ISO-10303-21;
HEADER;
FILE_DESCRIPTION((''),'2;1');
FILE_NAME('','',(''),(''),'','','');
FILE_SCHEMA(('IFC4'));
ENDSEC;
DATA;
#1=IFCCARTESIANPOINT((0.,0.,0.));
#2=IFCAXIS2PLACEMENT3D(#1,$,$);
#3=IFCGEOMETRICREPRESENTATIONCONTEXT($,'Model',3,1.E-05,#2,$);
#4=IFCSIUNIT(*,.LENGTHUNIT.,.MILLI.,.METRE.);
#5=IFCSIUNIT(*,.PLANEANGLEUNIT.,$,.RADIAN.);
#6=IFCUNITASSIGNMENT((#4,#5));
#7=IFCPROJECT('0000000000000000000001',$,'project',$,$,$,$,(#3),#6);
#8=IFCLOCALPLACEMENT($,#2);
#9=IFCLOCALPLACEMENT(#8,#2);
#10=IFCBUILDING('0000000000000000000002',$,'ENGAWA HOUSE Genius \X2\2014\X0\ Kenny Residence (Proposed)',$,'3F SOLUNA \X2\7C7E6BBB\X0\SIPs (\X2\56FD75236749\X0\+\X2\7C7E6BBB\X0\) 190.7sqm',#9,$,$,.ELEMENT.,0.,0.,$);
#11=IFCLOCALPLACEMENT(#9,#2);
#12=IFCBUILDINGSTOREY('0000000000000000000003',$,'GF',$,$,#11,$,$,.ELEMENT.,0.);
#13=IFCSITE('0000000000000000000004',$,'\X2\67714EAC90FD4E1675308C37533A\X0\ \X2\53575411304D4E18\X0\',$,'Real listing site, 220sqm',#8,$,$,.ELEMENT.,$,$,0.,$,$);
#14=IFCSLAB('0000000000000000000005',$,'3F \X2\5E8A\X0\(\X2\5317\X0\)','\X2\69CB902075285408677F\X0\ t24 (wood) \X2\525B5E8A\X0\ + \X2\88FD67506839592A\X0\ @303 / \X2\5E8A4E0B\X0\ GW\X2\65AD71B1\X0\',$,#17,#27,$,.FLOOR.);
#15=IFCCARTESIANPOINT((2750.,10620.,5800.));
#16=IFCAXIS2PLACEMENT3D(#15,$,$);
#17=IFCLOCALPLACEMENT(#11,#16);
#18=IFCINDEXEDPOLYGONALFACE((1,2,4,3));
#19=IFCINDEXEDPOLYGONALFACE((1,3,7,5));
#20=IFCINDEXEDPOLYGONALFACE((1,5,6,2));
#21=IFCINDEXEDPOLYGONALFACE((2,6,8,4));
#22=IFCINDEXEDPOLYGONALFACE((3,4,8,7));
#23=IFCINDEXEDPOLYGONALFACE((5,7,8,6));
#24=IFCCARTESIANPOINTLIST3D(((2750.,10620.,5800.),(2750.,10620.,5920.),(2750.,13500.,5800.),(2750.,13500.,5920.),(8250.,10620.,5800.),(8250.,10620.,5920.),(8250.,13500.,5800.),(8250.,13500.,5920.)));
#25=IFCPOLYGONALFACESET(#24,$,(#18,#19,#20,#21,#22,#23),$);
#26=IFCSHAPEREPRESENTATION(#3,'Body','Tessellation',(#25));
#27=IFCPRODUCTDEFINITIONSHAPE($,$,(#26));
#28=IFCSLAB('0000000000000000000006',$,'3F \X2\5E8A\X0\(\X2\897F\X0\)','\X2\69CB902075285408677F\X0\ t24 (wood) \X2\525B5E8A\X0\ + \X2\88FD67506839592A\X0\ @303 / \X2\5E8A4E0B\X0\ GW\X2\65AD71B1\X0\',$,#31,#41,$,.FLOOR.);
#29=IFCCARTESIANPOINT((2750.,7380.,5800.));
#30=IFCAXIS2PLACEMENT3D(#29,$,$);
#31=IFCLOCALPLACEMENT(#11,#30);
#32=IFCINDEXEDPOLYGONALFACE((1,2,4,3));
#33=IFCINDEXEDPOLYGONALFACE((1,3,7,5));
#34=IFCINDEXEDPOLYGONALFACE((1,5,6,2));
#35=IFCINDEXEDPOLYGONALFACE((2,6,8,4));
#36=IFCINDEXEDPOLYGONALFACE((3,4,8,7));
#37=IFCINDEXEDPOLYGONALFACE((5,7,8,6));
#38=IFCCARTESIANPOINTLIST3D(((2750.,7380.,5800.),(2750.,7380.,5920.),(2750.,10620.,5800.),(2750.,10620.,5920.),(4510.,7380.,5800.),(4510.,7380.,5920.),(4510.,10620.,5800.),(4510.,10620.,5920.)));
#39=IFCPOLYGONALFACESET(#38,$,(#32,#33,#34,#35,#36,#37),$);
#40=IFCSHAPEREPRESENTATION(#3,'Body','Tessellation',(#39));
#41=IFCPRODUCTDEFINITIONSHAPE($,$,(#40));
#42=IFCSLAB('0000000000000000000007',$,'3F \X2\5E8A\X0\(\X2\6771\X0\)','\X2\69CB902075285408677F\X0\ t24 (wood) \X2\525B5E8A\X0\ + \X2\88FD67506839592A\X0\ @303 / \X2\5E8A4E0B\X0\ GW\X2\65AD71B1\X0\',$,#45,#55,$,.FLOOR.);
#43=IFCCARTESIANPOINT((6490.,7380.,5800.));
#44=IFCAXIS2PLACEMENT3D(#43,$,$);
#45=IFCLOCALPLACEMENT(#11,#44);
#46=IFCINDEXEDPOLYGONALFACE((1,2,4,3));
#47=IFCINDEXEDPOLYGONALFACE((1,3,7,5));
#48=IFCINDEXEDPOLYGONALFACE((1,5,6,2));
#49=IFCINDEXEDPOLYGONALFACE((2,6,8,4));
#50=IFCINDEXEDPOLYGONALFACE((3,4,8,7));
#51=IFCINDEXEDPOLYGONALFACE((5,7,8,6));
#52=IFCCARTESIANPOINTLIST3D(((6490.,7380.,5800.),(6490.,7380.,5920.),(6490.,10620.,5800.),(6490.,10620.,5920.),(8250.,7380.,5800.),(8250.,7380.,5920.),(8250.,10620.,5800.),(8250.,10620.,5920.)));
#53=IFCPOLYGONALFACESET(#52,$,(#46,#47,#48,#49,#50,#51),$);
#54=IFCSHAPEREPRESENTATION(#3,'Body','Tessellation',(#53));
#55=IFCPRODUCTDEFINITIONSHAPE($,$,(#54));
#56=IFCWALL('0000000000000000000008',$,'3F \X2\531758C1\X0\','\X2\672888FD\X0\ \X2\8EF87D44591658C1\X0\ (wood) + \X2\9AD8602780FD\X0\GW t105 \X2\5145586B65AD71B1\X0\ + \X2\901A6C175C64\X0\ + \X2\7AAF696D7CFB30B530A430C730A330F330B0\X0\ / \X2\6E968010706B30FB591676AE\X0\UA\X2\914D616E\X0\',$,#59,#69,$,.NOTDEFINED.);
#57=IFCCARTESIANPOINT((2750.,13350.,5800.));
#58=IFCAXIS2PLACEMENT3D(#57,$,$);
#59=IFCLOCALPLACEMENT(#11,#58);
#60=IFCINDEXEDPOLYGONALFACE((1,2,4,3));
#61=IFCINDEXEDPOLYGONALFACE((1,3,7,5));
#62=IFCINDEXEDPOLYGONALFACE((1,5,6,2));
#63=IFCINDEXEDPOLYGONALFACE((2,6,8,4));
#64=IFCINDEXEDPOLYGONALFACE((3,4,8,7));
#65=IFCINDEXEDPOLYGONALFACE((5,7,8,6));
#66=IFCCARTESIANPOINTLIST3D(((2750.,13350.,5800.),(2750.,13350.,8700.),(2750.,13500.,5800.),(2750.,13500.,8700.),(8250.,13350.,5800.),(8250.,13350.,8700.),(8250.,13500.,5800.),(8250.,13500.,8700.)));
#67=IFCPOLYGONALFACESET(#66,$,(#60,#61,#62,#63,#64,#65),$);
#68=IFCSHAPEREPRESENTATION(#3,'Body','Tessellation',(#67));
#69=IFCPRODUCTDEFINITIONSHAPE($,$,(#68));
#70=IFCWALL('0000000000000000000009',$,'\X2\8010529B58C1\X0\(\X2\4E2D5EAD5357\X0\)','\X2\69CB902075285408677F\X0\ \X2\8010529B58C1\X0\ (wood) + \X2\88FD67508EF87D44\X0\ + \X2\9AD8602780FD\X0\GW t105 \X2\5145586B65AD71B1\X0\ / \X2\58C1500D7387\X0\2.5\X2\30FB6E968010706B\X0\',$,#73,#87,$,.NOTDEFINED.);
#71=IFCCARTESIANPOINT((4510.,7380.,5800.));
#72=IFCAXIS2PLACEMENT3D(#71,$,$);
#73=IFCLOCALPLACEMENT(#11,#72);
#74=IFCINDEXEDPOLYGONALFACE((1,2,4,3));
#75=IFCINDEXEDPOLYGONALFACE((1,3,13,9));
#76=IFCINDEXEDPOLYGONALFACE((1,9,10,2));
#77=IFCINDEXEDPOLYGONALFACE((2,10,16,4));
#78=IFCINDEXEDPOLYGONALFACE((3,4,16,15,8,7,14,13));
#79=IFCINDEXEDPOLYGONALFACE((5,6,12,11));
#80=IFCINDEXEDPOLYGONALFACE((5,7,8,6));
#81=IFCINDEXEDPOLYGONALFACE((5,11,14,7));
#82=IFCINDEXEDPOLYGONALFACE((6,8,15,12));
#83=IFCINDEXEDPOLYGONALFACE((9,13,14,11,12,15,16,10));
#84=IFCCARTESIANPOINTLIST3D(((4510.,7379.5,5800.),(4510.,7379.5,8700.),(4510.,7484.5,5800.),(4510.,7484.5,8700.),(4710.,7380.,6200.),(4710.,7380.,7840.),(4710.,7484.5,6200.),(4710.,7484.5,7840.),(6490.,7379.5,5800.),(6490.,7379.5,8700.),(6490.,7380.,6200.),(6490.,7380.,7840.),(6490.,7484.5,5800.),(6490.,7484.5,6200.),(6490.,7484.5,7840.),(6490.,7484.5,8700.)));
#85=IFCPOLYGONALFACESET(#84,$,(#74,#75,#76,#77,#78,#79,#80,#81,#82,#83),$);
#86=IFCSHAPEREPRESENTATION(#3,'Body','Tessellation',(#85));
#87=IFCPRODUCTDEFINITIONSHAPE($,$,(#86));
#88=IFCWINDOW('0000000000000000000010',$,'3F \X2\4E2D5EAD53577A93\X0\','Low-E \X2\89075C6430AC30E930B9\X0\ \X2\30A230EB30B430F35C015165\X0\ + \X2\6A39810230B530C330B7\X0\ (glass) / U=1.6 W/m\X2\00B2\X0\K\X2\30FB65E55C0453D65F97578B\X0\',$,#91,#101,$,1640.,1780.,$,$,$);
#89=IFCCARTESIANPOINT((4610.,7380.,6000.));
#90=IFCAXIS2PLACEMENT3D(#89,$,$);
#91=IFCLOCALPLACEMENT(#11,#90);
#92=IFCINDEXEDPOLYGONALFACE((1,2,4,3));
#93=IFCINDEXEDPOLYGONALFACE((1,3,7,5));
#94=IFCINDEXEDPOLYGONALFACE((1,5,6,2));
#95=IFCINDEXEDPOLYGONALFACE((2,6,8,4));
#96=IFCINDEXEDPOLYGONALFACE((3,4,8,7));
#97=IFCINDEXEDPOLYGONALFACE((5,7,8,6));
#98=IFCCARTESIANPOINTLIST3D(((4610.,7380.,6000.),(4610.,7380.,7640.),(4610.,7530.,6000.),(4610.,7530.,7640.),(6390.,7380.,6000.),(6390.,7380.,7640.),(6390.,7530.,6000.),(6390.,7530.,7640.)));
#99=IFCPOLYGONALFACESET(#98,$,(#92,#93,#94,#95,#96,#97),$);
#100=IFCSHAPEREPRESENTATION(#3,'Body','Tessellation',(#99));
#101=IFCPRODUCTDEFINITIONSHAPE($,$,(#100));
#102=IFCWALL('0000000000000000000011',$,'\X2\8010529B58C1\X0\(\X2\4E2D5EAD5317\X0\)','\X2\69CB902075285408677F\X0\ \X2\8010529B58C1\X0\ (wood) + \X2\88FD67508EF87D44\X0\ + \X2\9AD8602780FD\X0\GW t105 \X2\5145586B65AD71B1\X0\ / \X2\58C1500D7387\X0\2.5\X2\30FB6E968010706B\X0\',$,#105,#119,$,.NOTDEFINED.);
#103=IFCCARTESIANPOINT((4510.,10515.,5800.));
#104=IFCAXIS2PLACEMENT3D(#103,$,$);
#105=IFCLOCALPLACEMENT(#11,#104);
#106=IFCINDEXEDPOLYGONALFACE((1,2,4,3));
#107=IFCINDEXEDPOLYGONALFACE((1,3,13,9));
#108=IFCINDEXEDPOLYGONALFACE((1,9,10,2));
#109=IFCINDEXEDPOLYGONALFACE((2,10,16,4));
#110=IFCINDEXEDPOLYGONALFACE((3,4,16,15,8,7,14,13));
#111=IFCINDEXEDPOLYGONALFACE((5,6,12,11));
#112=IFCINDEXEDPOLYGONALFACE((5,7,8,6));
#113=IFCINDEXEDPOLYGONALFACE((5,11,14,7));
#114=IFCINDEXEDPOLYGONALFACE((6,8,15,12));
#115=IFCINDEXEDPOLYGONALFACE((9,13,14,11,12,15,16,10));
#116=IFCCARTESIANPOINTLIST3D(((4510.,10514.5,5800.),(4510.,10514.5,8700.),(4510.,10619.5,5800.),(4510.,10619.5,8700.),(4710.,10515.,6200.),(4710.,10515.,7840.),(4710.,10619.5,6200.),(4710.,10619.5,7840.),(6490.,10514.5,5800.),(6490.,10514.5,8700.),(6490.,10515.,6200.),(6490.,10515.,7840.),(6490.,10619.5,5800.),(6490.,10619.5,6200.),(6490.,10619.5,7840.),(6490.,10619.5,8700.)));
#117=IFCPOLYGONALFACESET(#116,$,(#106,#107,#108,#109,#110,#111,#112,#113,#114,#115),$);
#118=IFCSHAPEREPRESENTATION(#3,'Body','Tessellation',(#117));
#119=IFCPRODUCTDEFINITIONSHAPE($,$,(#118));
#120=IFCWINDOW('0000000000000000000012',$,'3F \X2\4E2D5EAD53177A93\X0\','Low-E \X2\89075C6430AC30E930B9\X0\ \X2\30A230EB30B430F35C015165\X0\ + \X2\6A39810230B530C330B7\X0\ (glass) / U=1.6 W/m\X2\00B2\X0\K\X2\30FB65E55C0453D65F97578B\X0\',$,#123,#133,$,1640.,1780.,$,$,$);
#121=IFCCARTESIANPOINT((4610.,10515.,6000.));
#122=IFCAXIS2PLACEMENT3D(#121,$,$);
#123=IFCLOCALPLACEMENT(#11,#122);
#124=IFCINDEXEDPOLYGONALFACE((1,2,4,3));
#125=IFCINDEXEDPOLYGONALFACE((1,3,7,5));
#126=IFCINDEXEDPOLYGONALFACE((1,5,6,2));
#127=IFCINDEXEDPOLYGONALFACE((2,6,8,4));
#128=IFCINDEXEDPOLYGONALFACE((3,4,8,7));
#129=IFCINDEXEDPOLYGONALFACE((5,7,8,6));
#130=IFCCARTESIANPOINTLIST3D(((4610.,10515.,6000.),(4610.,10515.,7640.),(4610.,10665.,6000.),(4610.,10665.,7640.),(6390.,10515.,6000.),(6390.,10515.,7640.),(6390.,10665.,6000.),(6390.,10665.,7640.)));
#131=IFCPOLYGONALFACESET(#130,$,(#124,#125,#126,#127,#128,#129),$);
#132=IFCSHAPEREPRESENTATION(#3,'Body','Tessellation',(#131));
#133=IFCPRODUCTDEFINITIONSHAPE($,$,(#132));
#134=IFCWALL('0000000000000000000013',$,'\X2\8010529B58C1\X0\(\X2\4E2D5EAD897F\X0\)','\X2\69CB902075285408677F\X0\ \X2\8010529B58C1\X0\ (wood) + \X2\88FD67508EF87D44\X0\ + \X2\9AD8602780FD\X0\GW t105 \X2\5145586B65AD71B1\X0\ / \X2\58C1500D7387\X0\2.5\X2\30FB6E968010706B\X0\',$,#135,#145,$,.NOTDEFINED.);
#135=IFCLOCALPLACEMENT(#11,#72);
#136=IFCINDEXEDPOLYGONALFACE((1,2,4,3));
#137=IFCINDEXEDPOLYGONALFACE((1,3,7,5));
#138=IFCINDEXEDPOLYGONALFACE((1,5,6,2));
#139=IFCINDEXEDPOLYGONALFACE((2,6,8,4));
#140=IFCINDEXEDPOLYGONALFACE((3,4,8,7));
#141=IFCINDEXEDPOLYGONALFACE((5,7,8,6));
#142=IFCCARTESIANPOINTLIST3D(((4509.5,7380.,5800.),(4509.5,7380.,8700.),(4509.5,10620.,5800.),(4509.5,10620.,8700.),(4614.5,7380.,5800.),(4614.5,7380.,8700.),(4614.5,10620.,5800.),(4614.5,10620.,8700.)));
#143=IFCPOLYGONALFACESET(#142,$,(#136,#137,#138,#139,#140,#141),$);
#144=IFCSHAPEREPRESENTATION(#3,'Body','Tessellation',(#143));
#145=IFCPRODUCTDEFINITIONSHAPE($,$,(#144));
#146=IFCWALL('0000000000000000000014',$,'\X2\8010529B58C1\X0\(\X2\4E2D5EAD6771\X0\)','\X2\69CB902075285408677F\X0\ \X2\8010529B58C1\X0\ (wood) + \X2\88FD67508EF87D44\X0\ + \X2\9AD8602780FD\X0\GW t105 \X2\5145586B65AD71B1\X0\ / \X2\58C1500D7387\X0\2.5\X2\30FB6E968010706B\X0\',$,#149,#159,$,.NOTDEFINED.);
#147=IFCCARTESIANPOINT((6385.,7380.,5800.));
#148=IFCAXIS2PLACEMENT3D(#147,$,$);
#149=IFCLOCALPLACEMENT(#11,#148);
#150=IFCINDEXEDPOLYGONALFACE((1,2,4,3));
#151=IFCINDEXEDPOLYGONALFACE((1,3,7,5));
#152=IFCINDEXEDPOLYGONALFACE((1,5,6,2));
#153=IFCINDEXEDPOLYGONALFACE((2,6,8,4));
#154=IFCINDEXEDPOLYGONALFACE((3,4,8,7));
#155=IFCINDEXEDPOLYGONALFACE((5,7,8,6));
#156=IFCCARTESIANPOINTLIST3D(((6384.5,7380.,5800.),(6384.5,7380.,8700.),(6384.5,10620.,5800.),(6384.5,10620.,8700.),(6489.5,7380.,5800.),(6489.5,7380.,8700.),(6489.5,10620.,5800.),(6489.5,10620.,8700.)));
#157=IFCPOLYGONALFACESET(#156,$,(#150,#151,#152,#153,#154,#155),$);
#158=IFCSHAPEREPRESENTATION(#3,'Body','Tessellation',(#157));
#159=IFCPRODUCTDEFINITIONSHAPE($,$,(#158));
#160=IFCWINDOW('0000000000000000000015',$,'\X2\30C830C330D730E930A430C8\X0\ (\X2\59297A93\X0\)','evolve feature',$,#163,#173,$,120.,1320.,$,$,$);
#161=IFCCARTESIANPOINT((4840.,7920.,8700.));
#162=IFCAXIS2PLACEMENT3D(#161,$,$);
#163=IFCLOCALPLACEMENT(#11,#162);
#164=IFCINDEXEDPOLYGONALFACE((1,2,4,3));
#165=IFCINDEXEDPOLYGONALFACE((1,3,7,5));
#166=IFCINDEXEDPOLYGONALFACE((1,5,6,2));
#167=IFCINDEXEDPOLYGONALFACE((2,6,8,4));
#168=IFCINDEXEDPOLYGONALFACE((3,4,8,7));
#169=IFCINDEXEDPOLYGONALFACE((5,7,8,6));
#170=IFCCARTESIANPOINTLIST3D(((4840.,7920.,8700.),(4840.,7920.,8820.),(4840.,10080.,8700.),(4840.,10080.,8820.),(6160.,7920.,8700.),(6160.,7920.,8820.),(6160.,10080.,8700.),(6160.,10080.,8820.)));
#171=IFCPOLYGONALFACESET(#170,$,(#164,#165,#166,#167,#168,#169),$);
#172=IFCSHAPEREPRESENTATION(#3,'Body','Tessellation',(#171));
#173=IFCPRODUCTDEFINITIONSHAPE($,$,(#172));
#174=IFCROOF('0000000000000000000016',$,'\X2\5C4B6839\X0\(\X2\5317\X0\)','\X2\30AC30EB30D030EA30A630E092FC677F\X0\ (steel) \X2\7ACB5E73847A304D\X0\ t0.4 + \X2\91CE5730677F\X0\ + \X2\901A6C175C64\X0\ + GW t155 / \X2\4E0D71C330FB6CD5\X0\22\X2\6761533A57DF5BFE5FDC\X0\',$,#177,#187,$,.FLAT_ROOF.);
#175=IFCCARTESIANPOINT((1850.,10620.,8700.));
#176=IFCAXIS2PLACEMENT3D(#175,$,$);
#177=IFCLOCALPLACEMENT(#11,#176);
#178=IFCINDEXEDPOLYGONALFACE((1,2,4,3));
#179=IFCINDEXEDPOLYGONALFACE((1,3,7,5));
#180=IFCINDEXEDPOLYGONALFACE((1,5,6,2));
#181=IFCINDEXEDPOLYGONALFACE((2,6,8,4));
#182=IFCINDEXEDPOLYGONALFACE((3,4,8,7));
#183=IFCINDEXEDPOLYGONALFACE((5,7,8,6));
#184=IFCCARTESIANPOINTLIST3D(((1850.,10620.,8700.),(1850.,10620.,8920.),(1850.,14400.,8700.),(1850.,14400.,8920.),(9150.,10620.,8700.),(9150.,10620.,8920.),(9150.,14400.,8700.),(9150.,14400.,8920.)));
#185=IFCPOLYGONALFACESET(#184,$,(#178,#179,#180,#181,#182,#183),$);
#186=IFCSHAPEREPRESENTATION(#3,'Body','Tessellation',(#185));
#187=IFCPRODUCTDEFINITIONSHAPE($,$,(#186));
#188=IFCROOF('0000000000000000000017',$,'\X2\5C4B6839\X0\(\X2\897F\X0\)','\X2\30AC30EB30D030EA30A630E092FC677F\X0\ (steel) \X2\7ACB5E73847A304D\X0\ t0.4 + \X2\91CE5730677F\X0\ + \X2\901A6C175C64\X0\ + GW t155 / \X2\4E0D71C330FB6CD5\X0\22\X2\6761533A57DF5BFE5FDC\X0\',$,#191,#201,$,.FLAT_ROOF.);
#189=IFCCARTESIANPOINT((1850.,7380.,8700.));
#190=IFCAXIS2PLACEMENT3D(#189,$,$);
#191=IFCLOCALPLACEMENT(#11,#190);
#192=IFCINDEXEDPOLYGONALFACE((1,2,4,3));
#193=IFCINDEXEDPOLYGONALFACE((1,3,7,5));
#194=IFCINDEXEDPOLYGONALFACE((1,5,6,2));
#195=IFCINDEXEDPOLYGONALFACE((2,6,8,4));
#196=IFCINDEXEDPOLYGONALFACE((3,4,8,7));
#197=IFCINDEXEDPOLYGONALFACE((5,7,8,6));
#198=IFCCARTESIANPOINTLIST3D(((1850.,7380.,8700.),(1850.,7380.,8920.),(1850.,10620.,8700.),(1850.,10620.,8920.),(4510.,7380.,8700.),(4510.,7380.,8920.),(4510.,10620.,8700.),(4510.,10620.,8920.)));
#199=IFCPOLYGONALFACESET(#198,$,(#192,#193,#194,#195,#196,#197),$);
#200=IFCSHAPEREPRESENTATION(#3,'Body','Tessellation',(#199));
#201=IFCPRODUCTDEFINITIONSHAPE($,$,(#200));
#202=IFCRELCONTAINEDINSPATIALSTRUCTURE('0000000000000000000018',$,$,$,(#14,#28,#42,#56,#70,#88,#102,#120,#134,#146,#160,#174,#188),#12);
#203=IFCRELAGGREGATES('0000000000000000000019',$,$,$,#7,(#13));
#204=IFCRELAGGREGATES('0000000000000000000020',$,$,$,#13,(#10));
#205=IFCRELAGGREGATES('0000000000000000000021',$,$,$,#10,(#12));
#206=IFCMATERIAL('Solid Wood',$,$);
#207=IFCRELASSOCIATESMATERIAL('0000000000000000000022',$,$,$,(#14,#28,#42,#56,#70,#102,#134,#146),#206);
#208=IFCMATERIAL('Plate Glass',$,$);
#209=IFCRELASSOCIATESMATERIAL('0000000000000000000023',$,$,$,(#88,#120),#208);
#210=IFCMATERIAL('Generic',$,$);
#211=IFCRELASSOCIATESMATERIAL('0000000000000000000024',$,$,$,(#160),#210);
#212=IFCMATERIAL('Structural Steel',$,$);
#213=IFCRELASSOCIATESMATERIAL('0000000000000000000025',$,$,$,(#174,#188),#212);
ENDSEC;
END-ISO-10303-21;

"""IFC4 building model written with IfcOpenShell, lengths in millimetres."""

from ifc_helpers import new_model, si_unit, frame, frame_2d, origin, place, context, project, spatial, rectangle, extrude, material, element, fill, save


model = new_model("IFC4")

# Units and contexts
model_context = context("Model", 3, precision=1e-05, world=origin())
ifc_project = project(units=[si_unit("LENGTHUNIT", "METRE", prefix="MILLI"), si_unit("PLANEANGLEUNIT", "RADIAN")], contexts=[model_context])

# Site, building, storey
site_placement = place(None, origin())
site = spatial("IfcSite", under=ifc_project, at=site_placement, Name="東京都世田谷区 南向き丘", ObjectType="Real listing site, 220sqm", CompositionType="ELEMENT", RefElevation=0.0)
building_placement = place(site_placement, origin())
building = spatial("IfcBuilding", under=site, at=building_placement, Name="ENGAWA HOUSE Genius — Kenny Residence (Proposed)", ObjectType="3F SOLUNA 籾殻SIPs (国産杉+籾殻) 190.7sqm", CompositionType="ELEMENT", ElevationOfRefHeight=0.0, ElevationOfTerrain=0.0)
storey_placement = place(building_placement, origin())
storey = spatial("IfcBuildingStorey", under=building, at=storey_placement, Name="GF", CompositionType="ELEMENT", Elevation=0.0)

# Slabs
ifc_material_1 = material(Name="Solid Wood")
slab_1_placement = place(storey_placement, frame((2750.0, 10620.0, 5800.0)))
element("IfcSlab", 1, at=slab_1_placement, inside=storey, material=ifc_material_1, Name="3F 床(北)", Description="構造用合板 t24 (wood) 剛床 + 製材根太 @303 / 床下 GW断熱", PredefinedType="FLOOR", context=model_context, shape_type="SweptSolid", body=[
    extrude(rectangle(XDim=5500.0, YDim=2880.0, at=frame_2d((2750.0, 1440.0))), frame((2750.0, 10620.0, 5800.0)), (0.0, 0.0, 1.0), 120.0),
])
slab_2_placement = place(storey_placement, frame((2750.0, 7380.0, 5800.0)))
element("IfcSlab", 2, at=slab_2_placement, inside=storey, material=ifc_material_1, Name="3F 床(西)", Description="構造用合板 t24 (wood) 剛床 + 製材根太 @303 / 床下 GW断熱", PredefinedType="FLOOR", context=model_context, shape_type="SweptSolid", body=[
    extrude(rectangle(XDim=1760.0, YDim=3240.0, at=frame_2d((880.0, 1620.0))), frame((2750.0, 7380.0, 5800.0)), (0.0, 0.0, 1.0), 120.0),
])
slab_3_placement = place(storey_placement, frame((6490.0, 7380.0, 5800.0)))
element("IfcSlab", 3, at=slab_3_placement, inside=storey, material=ifc_material_1, Name="3F 床(東)", Description="構造用合板 t24 (wood) 剛床 + 製材根太 @303 / 床下 GW断熱", PredefinedType="FLOOR", context=model_context, shape_type="SweptSolid", body=[
    extrude(rectangle(XDim=1760.0, YDim=3240.0, at=frame_2d((880.0, 1620.0))), frame((6490.0, 7380.0, 5800.0)), (0.0, 0.0, 1.0), 120.0),
])

# Wall
wall_1_placement = place(storey_placement, frame((2750.0, 13350.0, 5800.0)))
element("IfcWall", 4, at=wall_1_placement, inside=storey, material=ifc_material_1, Name="3F 北壁", Description="木製 軸組外壁 (wood) + 高性能GW t105 充填断熱 + 通気層 + 窯業系サイディング / 準耐火・外皮UA配慮", PredefinedType="NOTDEFINED", context=model_context, shape_type="SweptSolid", body=[
    extrude(rectangle(XDim=5500.0, YDim=150.0, at=frame_2d((2750.0, 75.0))), frame((2750.0, 13350.0, 5800.0)), (0.0, 0.0, 1.0), 2900.0),
])

# Walls, openings, windows
wall_2_placement = place(storey_placement, frame((4510.0, 7380.0, 5800.0)))
wall_2 = element("IfcWall", 5, at=wall_2_placement, inside=storey, material=ifc_material_1, Name="耐力壁(中庭南)", Description="構造用合板 耐力壁 (wood) + 製材軸組 + 高性能GW t105 充填断熱 / 壁倍率2.5・準耐火", PredefinedType="NOTDEFINED", context=model_context, shape_type="SweptSolid", body=[
    extrude(rectangle(XDim=1980.0, YDim=105.0, at=frame_2d((990.0, 52.0))), frame((4510.0, 7380.0, 5800.0)), (0.0, 0.0, 1.0), 2900.0),
])
opening_1_placement = place(storey_placement, frame((4610.0, 7380.0, 6000.0)))
opening_1 = element("IfcOpeningElement", 6, at=opening_1_placement, cuts=wall_2, PredefinedType="NOTDEFINED", context=model_context, shape_type="SweptSolid", body=[
    extrude(rectangle(XDim=1780.0, YDim=150.0, at=frame_2d((890.0, 75.0))), frame((4610.0, 7380.0, 6000.0)), (0.0, 0.0, 1.0), 1640.0),
])
ifc_material_2 = material(Name="Plate Glass")
window_1_placement = place(storey_placement, frame((4610.0, 7380.0, 6000.0)))
window_1 = element("IfcWindow", 7, at=window_1_placement, inside=storey, material=ifc_material_2, Name="3F 中庭南窓", Description="Low-E 複層ガラス アルゴン封入 + 樹脂サッシ (glass) / U=1.6 W/m²K・日射取得型", OverallHeight=1640.0, OverallWidth=1780.0, context=model_context, shape_type="SweptSolid", body=[
    extrude(rectangle(XDim=1780.0, YDim=150.0, at=frame_2d((890.0, 75.0))), frame((4610.0, 7380.0, 6000.0)), (0.0, 0.0, 1.0), 1640.0),
])
fill(opening_1, window_1)
wall_3_placement = place(storey_placement, frame((4510.0, 10515.0, 5800.0)))
wall_3 = element("IfcWall", 8, at=wall_3_placement, inside=storey, material=ifc_material_1, Name="耐力壁(中庭北)", Description="構造用合板 耐力壁 (wood) + 製材軸組 + 高性能GW t105 充填断熱 / 壁倍率2.5・準耐火", PredefinedType="NOTDEFINED", context=model_context, shape_type="SweptSolid", body=[
    extrude(rectangle(XDim=1980.0, YDim=105.0, at=frame_2d((990.0, 52.0))), frame((4510.0, 10515.0, 5800.0)), (0.0, 0.0, 1.0), 2900.0),
])
opening_2_placement = place(storey_placement, frame((4610.0, 10515.0, 6000.0)))
opening_2 = element("IfcOpeningElement", 9, at=opening_2_placement, cuts=wall_3, PredefinedType="NOTDEFINED", context=model_context, shape_type="SweptSolid", body=[
    extrude(rectangle(XDim=1780.0, YDim=150.0, at=frame_2d((890.0, 75.0))), frame((4610.0, 10515.0, 6000.0)), (0.0, 0.0, 1.0), 1640.0),
])
window_2_placement = place(storey_placement, frame((4610.0, 10515.0, 6000.0)))
window_2 = element("IfcWindow", 10, at=window_2_placement, inside=storey, material=ifc_material_2, Name="3F 中庭北窓", Description="Low-E 複層ガラス アルゴン封入 + 樹脂サッシ (glass) / U=1.6 W/m²K・日射取得型", OverallHeight=1640.0, OverallWidth=1780.0, context=model_context, shape_type="SweptSolid", body=[
    extrude(rectangle(XDim=1780.0, YDim=150.0, at=frame_2d((890.0, 75.0))), frame((4610.0, 10515.0, 6000.0)), (0.0, 0.0, 1.0), 1640.0),
])
fill(opening_2, window_2)

# Walls
wall_4_placement = place(storey_placement, frame((4510.0, 7380.0, 5800.0)))
element("IfcWall", 11, at=wall_4_placement, inside=storey, material=ifc_material_1, Name="耐力壁(中庭西)", Description="構造用合板 耐力壁 (wood) + 製材軸組 + 高性能GW t105 充填断熱 / 壁倍率2.5・準耐火", PredefinedType="NOTDEFINED", context=model_context, shape_type="SweptSolid", body=[
    extrude(rectangle(XDim=105.0, YDim=3240.0, at=frame_2d((52.0, 1620.0))), frame((4510.0, 7380.0, 5800.0)), (0.0, 0.0, 1.0), 2900.0),
])
wall_5_placement = place(storey_placement, frame((6385.0, 7380.0, 5800.0)))
element("IfcWall", 12, at=wall_5_placement, inside=storey, material=ifc_material_1, Name="耐力壁(中庭東)", Description="構造用合板 耐力壁 (wood) + 製材軸組 + 高性能GW t105 充填断熱 / 壁倍率2.5・準耐火", PredefinedType="NOTDEFINED", context=model_context, shape_type="SweptSolid", body=[
    extrude(rectangle(XDim=105.0, YDim=3240.0, at=frame_2d((52.0, 1620.0))), frame((6385.0, 7380.0, 5800.0)), (0.0, 0.0, 1.0), 2900.0),
])

# Window
ifc_material_3 = material(Name="Generic")
window_3_placement = place(storey_placement, frame((4840.0, 7920.0, 8700.0)))
element("IfcWindow", 13, at=window_3_placement, inside=storey, material=ifc_material_3, Name="トップライト (天窓)", Description="evolve feature", OverallHeight=120.0, OverallWidth=1320.0, context=model_context, shape_type="SweptSolid", body=[
    extrude(rectangle(XDim=1320.0, YDim=2160.0, at=frame_2d((660.0, 1080.0))), frame((4840.0, 7920.0, 8700.0)), (0.0, 0.0, 1.0), 120.0),
])

# Roofs
ifc_material_4 = material(Name="Structural Steel")
for number, where, name in (
    (14, (1850.0, 10620.0, 8700.0), "屋根(北)"),
):
    element("IfcRoof", number, at=place(storey_placement, frame(where)), inside=storey, material=ifc_material_4, Name=name, Description="ガルバリウム鋼板 (steel) 立平葺き t0.4 + 野地板 + 通気層 + GW t155 / 不燃・法22条区域対応", PredefinedType="FLAT_ROOF", context=model_context, shape_type="SweptSolid", body=[
        extrude(rectangle(XDim=7300.0, YDim=3780.0, at=frame_2d((3650.0, 1890.0))), frame((1850.0, 10620.0, 8700.0)), (0.0, 0.0, 1.0), 220.0),
    ])
roof_1_placement = place(storey_placement, frame((1850.0, 7380.0, 8700.0)))
element("IfcRoof", 15, at=roof_1_placement, inside=storey, material=ifc_material_4, Name="屋根(西)", Description="ガルバリウム鋼板 (steel) 立平葺き t0.4 + 野地板 + 通気層 + GW t155 / 不燃・法22条区域対応", PredefinedType="FLAT_ROOF", context=model_context, shape_type="SweptSolid", body=[
    extrude(rectangle(XDim=2660.0, YDim=3240.0, at=frame_2d((1330.0, 1620.0))), frame((1850.0, 7380.0, 8700.0)), (0.0, 0.0, 1.0), 220.0),
])

save(model, "model.ifc")
